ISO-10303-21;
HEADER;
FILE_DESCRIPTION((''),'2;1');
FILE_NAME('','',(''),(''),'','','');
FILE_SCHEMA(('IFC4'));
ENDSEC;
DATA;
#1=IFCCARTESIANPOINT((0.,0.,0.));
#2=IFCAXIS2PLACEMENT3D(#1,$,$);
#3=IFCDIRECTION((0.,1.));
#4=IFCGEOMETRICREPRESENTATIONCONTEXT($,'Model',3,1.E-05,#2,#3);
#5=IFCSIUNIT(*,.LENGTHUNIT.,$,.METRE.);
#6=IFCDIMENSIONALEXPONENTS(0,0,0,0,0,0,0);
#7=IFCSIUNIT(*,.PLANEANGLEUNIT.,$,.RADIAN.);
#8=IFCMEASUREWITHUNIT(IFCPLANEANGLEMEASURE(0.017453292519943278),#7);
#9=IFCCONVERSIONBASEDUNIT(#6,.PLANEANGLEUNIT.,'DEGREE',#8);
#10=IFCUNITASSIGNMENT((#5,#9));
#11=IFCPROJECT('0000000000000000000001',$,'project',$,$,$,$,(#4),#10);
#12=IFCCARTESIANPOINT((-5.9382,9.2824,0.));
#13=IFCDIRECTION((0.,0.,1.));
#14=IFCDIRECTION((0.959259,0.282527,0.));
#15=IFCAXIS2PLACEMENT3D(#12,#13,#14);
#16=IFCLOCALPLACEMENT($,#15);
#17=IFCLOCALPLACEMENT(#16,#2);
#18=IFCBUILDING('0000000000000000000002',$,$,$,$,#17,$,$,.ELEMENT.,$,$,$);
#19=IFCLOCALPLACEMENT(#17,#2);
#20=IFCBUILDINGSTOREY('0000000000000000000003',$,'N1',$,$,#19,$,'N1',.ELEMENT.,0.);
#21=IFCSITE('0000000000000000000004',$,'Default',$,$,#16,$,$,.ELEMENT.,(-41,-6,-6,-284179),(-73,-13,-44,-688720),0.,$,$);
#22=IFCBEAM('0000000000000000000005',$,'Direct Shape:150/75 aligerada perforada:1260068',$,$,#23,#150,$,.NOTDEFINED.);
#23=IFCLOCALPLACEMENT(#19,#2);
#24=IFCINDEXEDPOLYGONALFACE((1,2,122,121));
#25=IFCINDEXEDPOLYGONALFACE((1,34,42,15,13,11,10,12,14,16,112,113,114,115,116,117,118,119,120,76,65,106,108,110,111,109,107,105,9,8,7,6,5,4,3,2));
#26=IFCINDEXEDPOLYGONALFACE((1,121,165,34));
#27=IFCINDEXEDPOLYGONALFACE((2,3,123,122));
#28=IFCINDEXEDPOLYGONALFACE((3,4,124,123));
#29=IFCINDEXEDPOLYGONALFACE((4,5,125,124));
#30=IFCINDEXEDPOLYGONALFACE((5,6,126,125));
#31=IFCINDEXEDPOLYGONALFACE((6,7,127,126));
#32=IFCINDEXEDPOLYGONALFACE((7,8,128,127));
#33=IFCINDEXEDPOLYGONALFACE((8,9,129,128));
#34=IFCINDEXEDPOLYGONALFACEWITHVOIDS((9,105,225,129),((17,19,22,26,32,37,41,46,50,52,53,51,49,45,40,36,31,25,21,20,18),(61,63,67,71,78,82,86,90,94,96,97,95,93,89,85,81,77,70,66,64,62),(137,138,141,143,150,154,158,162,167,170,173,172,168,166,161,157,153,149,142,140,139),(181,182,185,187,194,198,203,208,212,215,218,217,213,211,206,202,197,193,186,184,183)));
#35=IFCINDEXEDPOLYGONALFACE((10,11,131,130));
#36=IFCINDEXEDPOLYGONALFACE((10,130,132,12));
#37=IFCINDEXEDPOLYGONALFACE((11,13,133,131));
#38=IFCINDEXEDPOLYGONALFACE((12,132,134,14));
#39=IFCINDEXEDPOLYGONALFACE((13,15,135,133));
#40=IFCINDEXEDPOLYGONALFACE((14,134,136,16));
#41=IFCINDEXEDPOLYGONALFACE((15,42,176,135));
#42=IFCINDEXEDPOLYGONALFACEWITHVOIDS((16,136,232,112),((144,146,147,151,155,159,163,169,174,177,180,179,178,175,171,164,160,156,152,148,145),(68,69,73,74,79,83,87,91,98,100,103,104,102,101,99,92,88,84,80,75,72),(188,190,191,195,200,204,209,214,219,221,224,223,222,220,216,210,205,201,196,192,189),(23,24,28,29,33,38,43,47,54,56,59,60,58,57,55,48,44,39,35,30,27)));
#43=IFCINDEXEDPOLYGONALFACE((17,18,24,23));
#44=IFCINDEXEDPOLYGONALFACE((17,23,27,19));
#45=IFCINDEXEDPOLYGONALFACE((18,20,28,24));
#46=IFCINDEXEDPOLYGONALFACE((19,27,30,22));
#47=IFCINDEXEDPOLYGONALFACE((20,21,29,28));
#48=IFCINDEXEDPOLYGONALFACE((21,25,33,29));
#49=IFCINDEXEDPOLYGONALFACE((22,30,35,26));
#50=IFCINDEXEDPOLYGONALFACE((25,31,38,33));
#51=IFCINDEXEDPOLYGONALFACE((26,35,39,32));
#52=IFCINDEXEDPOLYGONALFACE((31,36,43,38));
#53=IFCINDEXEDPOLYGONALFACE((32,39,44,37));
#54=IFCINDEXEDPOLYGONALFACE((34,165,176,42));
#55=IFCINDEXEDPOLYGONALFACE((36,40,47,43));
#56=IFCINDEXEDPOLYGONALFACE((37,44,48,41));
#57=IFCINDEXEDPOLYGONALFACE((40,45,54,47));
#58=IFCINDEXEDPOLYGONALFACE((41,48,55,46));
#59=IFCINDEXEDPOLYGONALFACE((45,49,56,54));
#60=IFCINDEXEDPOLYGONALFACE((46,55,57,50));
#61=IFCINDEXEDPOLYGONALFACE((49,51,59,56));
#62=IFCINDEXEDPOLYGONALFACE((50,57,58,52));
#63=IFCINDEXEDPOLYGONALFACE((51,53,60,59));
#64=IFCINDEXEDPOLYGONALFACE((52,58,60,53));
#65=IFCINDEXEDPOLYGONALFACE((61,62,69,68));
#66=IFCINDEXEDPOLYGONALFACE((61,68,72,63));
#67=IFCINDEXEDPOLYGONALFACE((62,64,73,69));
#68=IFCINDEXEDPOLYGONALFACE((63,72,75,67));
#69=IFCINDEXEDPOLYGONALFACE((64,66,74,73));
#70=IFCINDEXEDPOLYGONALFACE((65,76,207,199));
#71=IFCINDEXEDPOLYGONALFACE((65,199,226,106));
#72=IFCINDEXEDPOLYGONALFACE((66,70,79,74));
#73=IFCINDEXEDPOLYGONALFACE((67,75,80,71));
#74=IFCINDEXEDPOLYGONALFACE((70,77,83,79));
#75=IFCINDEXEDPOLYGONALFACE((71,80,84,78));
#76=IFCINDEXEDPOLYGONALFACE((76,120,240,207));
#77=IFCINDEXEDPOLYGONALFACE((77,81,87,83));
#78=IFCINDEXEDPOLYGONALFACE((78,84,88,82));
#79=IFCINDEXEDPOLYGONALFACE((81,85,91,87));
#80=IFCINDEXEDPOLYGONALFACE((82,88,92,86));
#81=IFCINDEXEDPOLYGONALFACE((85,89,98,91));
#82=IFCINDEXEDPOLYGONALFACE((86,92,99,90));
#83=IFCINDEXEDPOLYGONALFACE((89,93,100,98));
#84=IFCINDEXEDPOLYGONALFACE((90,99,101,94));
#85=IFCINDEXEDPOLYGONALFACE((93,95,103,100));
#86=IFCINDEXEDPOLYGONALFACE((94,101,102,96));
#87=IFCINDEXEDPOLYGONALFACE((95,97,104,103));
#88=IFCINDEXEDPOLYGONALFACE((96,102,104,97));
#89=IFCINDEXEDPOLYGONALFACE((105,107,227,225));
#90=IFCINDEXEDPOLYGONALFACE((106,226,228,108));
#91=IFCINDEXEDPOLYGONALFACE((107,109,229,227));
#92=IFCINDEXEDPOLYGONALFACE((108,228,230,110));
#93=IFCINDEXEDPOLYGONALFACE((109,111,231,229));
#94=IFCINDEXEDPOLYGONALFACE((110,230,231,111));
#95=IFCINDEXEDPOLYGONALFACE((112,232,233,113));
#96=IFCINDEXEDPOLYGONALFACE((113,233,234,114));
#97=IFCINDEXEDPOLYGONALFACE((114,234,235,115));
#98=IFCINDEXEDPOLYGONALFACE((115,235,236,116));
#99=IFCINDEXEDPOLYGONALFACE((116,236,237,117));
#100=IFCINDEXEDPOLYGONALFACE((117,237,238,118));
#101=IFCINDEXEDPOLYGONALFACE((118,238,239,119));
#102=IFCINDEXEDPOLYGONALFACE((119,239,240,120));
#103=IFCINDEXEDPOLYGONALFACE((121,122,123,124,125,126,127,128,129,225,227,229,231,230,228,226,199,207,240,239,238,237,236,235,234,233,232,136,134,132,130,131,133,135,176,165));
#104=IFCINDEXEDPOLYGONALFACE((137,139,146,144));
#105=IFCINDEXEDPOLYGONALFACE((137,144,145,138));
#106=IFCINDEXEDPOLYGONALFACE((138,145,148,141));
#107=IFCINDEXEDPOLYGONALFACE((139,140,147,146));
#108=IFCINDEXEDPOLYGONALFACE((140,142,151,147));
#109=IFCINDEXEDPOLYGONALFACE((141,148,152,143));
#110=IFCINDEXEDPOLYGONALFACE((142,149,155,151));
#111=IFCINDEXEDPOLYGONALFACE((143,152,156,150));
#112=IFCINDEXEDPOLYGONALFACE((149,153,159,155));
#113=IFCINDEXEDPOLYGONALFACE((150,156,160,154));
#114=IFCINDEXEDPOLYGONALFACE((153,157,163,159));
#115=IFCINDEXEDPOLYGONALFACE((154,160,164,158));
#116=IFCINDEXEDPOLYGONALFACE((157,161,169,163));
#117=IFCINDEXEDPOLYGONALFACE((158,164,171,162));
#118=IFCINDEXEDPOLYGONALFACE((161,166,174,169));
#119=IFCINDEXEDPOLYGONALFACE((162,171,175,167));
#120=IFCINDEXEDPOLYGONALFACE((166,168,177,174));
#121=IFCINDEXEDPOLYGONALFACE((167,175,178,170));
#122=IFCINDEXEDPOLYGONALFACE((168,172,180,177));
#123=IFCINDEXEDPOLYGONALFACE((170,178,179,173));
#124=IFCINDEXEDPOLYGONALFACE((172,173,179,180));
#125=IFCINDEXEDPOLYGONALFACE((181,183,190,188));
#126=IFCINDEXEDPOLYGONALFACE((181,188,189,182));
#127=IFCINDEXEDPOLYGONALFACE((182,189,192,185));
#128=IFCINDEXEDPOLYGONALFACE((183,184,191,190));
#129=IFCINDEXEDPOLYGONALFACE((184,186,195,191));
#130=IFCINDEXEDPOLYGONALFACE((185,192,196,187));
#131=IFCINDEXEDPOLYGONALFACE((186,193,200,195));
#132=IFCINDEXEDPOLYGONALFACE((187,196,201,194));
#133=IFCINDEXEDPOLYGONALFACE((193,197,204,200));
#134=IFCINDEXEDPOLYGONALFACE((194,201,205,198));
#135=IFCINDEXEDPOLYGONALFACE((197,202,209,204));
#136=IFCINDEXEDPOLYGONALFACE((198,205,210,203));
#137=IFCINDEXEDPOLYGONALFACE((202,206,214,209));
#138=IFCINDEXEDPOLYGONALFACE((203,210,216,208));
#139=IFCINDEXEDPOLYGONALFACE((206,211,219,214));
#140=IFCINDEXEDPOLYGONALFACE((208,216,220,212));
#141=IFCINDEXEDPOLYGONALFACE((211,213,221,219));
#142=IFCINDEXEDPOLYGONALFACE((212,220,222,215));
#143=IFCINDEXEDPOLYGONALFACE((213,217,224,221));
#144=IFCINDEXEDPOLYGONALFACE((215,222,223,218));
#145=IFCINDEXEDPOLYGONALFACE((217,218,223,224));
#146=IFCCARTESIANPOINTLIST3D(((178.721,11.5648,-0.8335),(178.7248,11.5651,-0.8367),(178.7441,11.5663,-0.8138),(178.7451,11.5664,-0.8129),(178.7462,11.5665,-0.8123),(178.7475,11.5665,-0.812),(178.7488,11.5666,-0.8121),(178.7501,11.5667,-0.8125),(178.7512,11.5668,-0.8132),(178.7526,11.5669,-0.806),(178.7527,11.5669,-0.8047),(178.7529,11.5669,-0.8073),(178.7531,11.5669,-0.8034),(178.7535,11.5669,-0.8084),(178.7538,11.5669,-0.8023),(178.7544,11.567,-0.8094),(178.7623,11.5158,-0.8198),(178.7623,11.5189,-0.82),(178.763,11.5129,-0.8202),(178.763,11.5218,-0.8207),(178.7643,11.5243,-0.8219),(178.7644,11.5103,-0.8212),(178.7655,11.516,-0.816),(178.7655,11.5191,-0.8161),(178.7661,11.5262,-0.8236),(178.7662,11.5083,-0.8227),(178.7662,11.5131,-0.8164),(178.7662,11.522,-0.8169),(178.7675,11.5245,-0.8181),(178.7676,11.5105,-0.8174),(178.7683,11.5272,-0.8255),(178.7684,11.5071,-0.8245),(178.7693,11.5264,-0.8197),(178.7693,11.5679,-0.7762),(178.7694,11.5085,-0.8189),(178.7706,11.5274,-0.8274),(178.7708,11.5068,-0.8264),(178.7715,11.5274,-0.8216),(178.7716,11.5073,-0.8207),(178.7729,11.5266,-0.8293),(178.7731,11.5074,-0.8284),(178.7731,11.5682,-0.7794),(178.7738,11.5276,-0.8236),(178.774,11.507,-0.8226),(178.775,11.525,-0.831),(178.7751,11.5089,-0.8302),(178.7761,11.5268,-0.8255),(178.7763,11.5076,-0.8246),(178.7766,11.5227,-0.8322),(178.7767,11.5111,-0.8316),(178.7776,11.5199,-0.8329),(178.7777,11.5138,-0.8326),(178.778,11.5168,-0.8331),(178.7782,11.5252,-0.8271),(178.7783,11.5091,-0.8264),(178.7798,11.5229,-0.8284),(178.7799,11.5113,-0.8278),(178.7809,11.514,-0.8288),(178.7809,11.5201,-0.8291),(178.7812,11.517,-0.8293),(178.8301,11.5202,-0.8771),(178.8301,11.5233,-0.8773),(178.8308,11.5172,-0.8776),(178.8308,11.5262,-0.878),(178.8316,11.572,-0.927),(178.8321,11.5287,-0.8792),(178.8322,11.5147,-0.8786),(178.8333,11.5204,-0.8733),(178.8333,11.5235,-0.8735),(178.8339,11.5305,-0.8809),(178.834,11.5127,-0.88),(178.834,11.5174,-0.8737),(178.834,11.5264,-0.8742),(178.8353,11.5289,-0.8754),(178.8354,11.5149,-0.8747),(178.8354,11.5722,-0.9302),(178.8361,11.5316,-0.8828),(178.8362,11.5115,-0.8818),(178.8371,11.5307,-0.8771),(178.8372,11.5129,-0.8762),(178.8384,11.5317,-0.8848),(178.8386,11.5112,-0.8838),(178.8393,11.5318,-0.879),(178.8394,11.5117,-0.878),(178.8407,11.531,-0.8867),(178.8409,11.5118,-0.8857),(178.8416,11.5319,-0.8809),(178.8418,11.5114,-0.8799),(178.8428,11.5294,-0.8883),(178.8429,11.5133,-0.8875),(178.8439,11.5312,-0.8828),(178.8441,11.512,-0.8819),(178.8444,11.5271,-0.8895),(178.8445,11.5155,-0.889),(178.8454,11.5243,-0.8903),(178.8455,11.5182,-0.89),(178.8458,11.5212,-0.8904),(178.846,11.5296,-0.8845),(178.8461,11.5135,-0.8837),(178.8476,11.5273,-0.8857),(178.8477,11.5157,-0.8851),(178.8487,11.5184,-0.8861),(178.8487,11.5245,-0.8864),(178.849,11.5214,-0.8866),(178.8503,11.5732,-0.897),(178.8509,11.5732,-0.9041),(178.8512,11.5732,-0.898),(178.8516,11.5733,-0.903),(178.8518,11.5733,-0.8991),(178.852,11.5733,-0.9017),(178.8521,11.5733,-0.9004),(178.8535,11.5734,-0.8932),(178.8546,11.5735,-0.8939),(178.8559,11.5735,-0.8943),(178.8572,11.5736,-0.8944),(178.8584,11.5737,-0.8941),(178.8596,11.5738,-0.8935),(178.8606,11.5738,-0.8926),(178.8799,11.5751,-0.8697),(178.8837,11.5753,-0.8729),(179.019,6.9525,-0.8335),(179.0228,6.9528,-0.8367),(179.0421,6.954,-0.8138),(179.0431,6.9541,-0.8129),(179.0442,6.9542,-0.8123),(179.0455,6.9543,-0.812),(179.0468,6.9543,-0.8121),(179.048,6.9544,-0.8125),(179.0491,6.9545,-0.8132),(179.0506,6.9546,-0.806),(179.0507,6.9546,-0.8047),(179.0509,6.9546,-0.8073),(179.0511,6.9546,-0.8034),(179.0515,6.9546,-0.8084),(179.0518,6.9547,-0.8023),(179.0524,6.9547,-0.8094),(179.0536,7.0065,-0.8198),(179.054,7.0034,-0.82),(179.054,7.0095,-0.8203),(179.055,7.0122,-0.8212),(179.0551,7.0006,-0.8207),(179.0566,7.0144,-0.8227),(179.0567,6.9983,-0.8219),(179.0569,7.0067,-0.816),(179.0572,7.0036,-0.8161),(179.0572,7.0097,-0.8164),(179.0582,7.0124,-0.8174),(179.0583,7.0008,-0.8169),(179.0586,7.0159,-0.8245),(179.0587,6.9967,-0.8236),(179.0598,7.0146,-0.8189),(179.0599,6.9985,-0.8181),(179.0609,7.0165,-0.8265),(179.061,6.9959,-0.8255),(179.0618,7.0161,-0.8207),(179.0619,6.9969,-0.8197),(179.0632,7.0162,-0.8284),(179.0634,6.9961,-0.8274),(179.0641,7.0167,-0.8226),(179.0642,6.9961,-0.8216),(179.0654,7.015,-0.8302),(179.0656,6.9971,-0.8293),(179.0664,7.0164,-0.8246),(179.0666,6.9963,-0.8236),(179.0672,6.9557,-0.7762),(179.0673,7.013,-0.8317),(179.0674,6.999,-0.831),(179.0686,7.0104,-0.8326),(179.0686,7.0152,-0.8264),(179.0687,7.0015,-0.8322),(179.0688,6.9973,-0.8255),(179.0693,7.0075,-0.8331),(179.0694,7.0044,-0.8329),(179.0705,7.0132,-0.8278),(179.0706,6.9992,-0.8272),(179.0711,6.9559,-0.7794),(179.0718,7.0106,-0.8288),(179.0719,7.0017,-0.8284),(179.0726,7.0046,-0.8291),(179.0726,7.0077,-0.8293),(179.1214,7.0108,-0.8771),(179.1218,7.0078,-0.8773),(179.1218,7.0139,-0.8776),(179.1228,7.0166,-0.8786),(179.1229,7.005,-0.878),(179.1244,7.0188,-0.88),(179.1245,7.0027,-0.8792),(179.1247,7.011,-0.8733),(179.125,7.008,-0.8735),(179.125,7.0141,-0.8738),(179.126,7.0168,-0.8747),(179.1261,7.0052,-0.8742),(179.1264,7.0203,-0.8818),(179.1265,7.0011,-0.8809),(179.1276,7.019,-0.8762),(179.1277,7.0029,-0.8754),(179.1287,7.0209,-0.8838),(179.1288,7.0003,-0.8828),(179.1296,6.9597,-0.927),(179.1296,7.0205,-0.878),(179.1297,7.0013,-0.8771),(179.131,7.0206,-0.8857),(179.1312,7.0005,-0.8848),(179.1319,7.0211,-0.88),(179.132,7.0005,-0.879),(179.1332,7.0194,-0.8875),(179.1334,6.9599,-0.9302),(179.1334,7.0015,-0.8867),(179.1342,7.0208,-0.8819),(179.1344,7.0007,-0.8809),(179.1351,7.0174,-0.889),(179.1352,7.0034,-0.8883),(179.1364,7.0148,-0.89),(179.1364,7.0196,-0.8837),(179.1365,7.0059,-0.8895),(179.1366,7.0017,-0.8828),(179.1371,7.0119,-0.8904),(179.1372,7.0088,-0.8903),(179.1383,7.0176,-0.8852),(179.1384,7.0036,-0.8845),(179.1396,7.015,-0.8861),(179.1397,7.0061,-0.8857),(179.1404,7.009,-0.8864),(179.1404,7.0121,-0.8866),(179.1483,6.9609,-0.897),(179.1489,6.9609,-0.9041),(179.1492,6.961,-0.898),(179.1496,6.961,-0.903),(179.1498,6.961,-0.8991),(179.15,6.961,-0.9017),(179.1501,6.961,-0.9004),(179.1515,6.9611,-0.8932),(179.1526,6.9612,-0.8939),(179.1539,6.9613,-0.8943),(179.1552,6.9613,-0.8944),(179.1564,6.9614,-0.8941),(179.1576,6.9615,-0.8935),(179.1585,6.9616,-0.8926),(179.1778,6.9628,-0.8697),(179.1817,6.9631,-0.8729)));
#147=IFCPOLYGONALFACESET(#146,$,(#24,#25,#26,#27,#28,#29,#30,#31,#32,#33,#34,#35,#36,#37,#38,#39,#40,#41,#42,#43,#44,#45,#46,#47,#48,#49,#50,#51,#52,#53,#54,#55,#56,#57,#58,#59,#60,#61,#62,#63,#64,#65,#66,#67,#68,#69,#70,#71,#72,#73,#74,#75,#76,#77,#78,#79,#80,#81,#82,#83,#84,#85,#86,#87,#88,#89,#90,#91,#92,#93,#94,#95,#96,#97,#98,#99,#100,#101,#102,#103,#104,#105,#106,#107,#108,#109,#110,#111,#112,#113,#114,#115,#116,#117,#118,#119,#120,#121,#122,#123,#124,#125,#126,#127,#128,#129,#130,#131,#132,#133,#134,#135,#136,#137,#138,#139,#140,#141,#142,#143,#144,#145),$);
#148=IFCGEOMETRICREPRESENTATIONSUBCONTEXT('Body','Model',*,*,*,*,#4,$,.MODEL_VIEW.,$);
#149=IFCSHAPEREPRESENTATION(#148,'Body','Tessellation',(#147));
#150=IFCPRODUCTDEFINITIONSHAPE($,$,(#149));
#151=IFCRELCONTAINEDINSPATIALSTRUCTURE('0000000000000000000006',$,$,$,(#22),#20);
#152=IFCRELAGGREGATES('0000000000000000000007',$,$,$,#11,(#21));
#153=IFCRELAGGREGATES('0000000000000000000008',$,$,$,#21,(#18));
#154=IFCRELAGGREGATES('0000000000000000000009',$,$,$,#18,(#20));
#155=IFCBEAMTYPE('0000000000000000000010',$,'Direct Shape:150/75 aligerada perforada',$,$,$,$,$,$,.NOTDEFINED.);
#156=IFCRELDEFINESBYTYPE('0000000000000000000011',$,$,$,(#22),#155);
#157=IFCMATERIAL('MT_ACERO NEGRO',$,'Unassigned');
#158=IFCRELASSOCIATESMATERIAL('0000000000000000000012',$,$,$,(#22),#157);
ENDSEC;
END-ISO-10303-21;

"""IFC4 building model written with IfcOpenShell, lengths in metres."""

from ifc_helpers import new_model, entity, si_unit, converted_unit, direction, frame, frame_2d, origin, place, context, subcontext, project, spatial, circle, i_section, extrude, material, type_object, element, save


model = new_model("IFC4")

# Units and contexts
model_context = context("Model", 3, precision=1e-05, world=origin(), true_north=direction((0.0, 1.0)))
body_context = subcontext(model_context, "Body", "Model", "MODEL_VIEW")
ifc_project = project(units=[si_unit("LENGTHUNIT", "METRE"), converted_unit("PLANEANGLEUNIT", "DEGREE", entity("IfcPlaneAngleMeasure", 0.017453292519943278), si_unit("PLANEANGLEUNIT", "RADIAN"), dimensions=[0, 0, 0, 0, 0, 0, 0])], contexts=[model_context])

# Site, building, storey
site_placement = place(None, frame((-5.9382, 9.2824, 0.0), z_axis=(0.0, 0.0, 1.0), x_axis=(0.959259, 0.282527, 0.0)))
site = spatial("IfcSite", under=ifc_project, at=site_placement, Name="Default", CompositionType="ELEMENT", RefLatitude=(-41, -6, -6, -284179), RefLongitude=(-73, -13, -44, -688720), RefElevation=0.0)
building_placement = place(site_placement, origin())
building = spatial("IfcBuilding", under=site, at=building_placement, CompositionType="ELEMENT")
storey_placement = place(building_placement, origin())
storey = spatial("IfcBuildingStorey", under=building, at=storey_placement, Name="N1", LongName="N1", CompositionType="ELEMENT", Elevation=0.0)

# Beam, openings
ifc_material_1 = material(Name="MT_ACERO NEGRO", Category="Unassigned")
beam_type_1 = type_object("IfcBeamType", Name="Direct Shape:150/75 aligerada perforada", PredefinedType="NOTDEFINED")
beam_1_placement = place(storey_placement, origin())
beam_1 = element("IfcBeam", 1, at=beam_1_placement, inside=storey, type_object=beam_type_1, material=ifc_material_1, Name="Direct Shape:150/75 aligerada perforada:1260068", PredefinedType="NOTDEFINED", context=body_context, shape_type="SweptSolid", body=[
    extrude(i_section(OverallWidth=0.075, OverallDepth=0.15, WebThickness=0.005, FlangeThickness=0.005, FilletRadius=0.005, at=frame_2d((0.0, 0.0), x_axis=(0.0, 1.0))), frame((179.1003, 6.9578, -0.8532), z_axis=(-0.064471, 0.99792, 0.0), x_axis=(-0.762769, -0.049279, 0.644791)), (0.0, 0.0, 1.0), 4.6219),
])
opening_1_placement = place(storey_placement, origin())
element("IfcOpeningElement", 2, at=opening_1_placement, cuts=beam_1, PredefinedType="OPENING", context=body_context, shape_type="SweptSolid", body=[
    extrude(circle(Radius=0.0103, at=frame_2d((0.0, 0.0), x_axis=(1.0, 0.0))), frame((178.7701, 11.5171, -0.8264), z_axis=(0.64345, 0.041569, 0.764359), x_axis=(0.064473, -0.997919, -0.000004)), (0.0, 0.0, 1.0), 0.005),
])
opening_2_placement = place(storey_placement, origin())
element("IfcOpeningElement", 3, at=opening_2_placement, cuts=beam_1, PredefinedType="OPENING", context=body_context, shape_type="SweptSolid", body=[
    extrude(circle(Radius=0.0103, at=frame_2d((0.0, 0.0), x_axis=(1.0, 0.0))), frame((178.8379, 11.5215, -0.8838), z_axis=(0.64345, 0.041569, 0.764359), x_axis=(0.064474, -0.997919, -0.000004)), (0.0, 0.0, 1.0), 0.005),
])
opening_3_placement = place(storey_placement, origin())
element("IfcOpeningElement", 4, at=opening_3_placement, cuts=beam_1, PredefinedType="OPENING", context=body_context, shape_type="SweptSolid", body=[
    extrude(circle(Radius=0.0103, at=frame_2d((0.0, 0.0), x_axis=(1.0, 0.0))), frame((179.1293, 7.0106, -0.8838), z_axis=(0.64345, 0.041569, 0.764359), x_axis=(-0.064467, 0.99792, -0.000001)), (0.0, 0.0, 1.0), 0.005),
])
opening_4_placement = place(storey_placement, origin())
element("IfcOpeningElement", 5, at=opening_4_placement, cuts=beam_1, PredefinedType="OPENING", context=body_context, shape_type="SweptSolid", body=[
    extrude(circle(Radius=0.0103, at=frame_2d((0.0, 0.0), x_axis=(1.0, 0.0))), frame((179.0615, 7.0062, -0.8265), z_axis=(0.64345, 0.041569, 0.764359), x_axis=(-0.064467, 0.99792, -0.000001)), (0.0, 0.0, 1.0), 0.005),
])

save(model, "model.ifc")
